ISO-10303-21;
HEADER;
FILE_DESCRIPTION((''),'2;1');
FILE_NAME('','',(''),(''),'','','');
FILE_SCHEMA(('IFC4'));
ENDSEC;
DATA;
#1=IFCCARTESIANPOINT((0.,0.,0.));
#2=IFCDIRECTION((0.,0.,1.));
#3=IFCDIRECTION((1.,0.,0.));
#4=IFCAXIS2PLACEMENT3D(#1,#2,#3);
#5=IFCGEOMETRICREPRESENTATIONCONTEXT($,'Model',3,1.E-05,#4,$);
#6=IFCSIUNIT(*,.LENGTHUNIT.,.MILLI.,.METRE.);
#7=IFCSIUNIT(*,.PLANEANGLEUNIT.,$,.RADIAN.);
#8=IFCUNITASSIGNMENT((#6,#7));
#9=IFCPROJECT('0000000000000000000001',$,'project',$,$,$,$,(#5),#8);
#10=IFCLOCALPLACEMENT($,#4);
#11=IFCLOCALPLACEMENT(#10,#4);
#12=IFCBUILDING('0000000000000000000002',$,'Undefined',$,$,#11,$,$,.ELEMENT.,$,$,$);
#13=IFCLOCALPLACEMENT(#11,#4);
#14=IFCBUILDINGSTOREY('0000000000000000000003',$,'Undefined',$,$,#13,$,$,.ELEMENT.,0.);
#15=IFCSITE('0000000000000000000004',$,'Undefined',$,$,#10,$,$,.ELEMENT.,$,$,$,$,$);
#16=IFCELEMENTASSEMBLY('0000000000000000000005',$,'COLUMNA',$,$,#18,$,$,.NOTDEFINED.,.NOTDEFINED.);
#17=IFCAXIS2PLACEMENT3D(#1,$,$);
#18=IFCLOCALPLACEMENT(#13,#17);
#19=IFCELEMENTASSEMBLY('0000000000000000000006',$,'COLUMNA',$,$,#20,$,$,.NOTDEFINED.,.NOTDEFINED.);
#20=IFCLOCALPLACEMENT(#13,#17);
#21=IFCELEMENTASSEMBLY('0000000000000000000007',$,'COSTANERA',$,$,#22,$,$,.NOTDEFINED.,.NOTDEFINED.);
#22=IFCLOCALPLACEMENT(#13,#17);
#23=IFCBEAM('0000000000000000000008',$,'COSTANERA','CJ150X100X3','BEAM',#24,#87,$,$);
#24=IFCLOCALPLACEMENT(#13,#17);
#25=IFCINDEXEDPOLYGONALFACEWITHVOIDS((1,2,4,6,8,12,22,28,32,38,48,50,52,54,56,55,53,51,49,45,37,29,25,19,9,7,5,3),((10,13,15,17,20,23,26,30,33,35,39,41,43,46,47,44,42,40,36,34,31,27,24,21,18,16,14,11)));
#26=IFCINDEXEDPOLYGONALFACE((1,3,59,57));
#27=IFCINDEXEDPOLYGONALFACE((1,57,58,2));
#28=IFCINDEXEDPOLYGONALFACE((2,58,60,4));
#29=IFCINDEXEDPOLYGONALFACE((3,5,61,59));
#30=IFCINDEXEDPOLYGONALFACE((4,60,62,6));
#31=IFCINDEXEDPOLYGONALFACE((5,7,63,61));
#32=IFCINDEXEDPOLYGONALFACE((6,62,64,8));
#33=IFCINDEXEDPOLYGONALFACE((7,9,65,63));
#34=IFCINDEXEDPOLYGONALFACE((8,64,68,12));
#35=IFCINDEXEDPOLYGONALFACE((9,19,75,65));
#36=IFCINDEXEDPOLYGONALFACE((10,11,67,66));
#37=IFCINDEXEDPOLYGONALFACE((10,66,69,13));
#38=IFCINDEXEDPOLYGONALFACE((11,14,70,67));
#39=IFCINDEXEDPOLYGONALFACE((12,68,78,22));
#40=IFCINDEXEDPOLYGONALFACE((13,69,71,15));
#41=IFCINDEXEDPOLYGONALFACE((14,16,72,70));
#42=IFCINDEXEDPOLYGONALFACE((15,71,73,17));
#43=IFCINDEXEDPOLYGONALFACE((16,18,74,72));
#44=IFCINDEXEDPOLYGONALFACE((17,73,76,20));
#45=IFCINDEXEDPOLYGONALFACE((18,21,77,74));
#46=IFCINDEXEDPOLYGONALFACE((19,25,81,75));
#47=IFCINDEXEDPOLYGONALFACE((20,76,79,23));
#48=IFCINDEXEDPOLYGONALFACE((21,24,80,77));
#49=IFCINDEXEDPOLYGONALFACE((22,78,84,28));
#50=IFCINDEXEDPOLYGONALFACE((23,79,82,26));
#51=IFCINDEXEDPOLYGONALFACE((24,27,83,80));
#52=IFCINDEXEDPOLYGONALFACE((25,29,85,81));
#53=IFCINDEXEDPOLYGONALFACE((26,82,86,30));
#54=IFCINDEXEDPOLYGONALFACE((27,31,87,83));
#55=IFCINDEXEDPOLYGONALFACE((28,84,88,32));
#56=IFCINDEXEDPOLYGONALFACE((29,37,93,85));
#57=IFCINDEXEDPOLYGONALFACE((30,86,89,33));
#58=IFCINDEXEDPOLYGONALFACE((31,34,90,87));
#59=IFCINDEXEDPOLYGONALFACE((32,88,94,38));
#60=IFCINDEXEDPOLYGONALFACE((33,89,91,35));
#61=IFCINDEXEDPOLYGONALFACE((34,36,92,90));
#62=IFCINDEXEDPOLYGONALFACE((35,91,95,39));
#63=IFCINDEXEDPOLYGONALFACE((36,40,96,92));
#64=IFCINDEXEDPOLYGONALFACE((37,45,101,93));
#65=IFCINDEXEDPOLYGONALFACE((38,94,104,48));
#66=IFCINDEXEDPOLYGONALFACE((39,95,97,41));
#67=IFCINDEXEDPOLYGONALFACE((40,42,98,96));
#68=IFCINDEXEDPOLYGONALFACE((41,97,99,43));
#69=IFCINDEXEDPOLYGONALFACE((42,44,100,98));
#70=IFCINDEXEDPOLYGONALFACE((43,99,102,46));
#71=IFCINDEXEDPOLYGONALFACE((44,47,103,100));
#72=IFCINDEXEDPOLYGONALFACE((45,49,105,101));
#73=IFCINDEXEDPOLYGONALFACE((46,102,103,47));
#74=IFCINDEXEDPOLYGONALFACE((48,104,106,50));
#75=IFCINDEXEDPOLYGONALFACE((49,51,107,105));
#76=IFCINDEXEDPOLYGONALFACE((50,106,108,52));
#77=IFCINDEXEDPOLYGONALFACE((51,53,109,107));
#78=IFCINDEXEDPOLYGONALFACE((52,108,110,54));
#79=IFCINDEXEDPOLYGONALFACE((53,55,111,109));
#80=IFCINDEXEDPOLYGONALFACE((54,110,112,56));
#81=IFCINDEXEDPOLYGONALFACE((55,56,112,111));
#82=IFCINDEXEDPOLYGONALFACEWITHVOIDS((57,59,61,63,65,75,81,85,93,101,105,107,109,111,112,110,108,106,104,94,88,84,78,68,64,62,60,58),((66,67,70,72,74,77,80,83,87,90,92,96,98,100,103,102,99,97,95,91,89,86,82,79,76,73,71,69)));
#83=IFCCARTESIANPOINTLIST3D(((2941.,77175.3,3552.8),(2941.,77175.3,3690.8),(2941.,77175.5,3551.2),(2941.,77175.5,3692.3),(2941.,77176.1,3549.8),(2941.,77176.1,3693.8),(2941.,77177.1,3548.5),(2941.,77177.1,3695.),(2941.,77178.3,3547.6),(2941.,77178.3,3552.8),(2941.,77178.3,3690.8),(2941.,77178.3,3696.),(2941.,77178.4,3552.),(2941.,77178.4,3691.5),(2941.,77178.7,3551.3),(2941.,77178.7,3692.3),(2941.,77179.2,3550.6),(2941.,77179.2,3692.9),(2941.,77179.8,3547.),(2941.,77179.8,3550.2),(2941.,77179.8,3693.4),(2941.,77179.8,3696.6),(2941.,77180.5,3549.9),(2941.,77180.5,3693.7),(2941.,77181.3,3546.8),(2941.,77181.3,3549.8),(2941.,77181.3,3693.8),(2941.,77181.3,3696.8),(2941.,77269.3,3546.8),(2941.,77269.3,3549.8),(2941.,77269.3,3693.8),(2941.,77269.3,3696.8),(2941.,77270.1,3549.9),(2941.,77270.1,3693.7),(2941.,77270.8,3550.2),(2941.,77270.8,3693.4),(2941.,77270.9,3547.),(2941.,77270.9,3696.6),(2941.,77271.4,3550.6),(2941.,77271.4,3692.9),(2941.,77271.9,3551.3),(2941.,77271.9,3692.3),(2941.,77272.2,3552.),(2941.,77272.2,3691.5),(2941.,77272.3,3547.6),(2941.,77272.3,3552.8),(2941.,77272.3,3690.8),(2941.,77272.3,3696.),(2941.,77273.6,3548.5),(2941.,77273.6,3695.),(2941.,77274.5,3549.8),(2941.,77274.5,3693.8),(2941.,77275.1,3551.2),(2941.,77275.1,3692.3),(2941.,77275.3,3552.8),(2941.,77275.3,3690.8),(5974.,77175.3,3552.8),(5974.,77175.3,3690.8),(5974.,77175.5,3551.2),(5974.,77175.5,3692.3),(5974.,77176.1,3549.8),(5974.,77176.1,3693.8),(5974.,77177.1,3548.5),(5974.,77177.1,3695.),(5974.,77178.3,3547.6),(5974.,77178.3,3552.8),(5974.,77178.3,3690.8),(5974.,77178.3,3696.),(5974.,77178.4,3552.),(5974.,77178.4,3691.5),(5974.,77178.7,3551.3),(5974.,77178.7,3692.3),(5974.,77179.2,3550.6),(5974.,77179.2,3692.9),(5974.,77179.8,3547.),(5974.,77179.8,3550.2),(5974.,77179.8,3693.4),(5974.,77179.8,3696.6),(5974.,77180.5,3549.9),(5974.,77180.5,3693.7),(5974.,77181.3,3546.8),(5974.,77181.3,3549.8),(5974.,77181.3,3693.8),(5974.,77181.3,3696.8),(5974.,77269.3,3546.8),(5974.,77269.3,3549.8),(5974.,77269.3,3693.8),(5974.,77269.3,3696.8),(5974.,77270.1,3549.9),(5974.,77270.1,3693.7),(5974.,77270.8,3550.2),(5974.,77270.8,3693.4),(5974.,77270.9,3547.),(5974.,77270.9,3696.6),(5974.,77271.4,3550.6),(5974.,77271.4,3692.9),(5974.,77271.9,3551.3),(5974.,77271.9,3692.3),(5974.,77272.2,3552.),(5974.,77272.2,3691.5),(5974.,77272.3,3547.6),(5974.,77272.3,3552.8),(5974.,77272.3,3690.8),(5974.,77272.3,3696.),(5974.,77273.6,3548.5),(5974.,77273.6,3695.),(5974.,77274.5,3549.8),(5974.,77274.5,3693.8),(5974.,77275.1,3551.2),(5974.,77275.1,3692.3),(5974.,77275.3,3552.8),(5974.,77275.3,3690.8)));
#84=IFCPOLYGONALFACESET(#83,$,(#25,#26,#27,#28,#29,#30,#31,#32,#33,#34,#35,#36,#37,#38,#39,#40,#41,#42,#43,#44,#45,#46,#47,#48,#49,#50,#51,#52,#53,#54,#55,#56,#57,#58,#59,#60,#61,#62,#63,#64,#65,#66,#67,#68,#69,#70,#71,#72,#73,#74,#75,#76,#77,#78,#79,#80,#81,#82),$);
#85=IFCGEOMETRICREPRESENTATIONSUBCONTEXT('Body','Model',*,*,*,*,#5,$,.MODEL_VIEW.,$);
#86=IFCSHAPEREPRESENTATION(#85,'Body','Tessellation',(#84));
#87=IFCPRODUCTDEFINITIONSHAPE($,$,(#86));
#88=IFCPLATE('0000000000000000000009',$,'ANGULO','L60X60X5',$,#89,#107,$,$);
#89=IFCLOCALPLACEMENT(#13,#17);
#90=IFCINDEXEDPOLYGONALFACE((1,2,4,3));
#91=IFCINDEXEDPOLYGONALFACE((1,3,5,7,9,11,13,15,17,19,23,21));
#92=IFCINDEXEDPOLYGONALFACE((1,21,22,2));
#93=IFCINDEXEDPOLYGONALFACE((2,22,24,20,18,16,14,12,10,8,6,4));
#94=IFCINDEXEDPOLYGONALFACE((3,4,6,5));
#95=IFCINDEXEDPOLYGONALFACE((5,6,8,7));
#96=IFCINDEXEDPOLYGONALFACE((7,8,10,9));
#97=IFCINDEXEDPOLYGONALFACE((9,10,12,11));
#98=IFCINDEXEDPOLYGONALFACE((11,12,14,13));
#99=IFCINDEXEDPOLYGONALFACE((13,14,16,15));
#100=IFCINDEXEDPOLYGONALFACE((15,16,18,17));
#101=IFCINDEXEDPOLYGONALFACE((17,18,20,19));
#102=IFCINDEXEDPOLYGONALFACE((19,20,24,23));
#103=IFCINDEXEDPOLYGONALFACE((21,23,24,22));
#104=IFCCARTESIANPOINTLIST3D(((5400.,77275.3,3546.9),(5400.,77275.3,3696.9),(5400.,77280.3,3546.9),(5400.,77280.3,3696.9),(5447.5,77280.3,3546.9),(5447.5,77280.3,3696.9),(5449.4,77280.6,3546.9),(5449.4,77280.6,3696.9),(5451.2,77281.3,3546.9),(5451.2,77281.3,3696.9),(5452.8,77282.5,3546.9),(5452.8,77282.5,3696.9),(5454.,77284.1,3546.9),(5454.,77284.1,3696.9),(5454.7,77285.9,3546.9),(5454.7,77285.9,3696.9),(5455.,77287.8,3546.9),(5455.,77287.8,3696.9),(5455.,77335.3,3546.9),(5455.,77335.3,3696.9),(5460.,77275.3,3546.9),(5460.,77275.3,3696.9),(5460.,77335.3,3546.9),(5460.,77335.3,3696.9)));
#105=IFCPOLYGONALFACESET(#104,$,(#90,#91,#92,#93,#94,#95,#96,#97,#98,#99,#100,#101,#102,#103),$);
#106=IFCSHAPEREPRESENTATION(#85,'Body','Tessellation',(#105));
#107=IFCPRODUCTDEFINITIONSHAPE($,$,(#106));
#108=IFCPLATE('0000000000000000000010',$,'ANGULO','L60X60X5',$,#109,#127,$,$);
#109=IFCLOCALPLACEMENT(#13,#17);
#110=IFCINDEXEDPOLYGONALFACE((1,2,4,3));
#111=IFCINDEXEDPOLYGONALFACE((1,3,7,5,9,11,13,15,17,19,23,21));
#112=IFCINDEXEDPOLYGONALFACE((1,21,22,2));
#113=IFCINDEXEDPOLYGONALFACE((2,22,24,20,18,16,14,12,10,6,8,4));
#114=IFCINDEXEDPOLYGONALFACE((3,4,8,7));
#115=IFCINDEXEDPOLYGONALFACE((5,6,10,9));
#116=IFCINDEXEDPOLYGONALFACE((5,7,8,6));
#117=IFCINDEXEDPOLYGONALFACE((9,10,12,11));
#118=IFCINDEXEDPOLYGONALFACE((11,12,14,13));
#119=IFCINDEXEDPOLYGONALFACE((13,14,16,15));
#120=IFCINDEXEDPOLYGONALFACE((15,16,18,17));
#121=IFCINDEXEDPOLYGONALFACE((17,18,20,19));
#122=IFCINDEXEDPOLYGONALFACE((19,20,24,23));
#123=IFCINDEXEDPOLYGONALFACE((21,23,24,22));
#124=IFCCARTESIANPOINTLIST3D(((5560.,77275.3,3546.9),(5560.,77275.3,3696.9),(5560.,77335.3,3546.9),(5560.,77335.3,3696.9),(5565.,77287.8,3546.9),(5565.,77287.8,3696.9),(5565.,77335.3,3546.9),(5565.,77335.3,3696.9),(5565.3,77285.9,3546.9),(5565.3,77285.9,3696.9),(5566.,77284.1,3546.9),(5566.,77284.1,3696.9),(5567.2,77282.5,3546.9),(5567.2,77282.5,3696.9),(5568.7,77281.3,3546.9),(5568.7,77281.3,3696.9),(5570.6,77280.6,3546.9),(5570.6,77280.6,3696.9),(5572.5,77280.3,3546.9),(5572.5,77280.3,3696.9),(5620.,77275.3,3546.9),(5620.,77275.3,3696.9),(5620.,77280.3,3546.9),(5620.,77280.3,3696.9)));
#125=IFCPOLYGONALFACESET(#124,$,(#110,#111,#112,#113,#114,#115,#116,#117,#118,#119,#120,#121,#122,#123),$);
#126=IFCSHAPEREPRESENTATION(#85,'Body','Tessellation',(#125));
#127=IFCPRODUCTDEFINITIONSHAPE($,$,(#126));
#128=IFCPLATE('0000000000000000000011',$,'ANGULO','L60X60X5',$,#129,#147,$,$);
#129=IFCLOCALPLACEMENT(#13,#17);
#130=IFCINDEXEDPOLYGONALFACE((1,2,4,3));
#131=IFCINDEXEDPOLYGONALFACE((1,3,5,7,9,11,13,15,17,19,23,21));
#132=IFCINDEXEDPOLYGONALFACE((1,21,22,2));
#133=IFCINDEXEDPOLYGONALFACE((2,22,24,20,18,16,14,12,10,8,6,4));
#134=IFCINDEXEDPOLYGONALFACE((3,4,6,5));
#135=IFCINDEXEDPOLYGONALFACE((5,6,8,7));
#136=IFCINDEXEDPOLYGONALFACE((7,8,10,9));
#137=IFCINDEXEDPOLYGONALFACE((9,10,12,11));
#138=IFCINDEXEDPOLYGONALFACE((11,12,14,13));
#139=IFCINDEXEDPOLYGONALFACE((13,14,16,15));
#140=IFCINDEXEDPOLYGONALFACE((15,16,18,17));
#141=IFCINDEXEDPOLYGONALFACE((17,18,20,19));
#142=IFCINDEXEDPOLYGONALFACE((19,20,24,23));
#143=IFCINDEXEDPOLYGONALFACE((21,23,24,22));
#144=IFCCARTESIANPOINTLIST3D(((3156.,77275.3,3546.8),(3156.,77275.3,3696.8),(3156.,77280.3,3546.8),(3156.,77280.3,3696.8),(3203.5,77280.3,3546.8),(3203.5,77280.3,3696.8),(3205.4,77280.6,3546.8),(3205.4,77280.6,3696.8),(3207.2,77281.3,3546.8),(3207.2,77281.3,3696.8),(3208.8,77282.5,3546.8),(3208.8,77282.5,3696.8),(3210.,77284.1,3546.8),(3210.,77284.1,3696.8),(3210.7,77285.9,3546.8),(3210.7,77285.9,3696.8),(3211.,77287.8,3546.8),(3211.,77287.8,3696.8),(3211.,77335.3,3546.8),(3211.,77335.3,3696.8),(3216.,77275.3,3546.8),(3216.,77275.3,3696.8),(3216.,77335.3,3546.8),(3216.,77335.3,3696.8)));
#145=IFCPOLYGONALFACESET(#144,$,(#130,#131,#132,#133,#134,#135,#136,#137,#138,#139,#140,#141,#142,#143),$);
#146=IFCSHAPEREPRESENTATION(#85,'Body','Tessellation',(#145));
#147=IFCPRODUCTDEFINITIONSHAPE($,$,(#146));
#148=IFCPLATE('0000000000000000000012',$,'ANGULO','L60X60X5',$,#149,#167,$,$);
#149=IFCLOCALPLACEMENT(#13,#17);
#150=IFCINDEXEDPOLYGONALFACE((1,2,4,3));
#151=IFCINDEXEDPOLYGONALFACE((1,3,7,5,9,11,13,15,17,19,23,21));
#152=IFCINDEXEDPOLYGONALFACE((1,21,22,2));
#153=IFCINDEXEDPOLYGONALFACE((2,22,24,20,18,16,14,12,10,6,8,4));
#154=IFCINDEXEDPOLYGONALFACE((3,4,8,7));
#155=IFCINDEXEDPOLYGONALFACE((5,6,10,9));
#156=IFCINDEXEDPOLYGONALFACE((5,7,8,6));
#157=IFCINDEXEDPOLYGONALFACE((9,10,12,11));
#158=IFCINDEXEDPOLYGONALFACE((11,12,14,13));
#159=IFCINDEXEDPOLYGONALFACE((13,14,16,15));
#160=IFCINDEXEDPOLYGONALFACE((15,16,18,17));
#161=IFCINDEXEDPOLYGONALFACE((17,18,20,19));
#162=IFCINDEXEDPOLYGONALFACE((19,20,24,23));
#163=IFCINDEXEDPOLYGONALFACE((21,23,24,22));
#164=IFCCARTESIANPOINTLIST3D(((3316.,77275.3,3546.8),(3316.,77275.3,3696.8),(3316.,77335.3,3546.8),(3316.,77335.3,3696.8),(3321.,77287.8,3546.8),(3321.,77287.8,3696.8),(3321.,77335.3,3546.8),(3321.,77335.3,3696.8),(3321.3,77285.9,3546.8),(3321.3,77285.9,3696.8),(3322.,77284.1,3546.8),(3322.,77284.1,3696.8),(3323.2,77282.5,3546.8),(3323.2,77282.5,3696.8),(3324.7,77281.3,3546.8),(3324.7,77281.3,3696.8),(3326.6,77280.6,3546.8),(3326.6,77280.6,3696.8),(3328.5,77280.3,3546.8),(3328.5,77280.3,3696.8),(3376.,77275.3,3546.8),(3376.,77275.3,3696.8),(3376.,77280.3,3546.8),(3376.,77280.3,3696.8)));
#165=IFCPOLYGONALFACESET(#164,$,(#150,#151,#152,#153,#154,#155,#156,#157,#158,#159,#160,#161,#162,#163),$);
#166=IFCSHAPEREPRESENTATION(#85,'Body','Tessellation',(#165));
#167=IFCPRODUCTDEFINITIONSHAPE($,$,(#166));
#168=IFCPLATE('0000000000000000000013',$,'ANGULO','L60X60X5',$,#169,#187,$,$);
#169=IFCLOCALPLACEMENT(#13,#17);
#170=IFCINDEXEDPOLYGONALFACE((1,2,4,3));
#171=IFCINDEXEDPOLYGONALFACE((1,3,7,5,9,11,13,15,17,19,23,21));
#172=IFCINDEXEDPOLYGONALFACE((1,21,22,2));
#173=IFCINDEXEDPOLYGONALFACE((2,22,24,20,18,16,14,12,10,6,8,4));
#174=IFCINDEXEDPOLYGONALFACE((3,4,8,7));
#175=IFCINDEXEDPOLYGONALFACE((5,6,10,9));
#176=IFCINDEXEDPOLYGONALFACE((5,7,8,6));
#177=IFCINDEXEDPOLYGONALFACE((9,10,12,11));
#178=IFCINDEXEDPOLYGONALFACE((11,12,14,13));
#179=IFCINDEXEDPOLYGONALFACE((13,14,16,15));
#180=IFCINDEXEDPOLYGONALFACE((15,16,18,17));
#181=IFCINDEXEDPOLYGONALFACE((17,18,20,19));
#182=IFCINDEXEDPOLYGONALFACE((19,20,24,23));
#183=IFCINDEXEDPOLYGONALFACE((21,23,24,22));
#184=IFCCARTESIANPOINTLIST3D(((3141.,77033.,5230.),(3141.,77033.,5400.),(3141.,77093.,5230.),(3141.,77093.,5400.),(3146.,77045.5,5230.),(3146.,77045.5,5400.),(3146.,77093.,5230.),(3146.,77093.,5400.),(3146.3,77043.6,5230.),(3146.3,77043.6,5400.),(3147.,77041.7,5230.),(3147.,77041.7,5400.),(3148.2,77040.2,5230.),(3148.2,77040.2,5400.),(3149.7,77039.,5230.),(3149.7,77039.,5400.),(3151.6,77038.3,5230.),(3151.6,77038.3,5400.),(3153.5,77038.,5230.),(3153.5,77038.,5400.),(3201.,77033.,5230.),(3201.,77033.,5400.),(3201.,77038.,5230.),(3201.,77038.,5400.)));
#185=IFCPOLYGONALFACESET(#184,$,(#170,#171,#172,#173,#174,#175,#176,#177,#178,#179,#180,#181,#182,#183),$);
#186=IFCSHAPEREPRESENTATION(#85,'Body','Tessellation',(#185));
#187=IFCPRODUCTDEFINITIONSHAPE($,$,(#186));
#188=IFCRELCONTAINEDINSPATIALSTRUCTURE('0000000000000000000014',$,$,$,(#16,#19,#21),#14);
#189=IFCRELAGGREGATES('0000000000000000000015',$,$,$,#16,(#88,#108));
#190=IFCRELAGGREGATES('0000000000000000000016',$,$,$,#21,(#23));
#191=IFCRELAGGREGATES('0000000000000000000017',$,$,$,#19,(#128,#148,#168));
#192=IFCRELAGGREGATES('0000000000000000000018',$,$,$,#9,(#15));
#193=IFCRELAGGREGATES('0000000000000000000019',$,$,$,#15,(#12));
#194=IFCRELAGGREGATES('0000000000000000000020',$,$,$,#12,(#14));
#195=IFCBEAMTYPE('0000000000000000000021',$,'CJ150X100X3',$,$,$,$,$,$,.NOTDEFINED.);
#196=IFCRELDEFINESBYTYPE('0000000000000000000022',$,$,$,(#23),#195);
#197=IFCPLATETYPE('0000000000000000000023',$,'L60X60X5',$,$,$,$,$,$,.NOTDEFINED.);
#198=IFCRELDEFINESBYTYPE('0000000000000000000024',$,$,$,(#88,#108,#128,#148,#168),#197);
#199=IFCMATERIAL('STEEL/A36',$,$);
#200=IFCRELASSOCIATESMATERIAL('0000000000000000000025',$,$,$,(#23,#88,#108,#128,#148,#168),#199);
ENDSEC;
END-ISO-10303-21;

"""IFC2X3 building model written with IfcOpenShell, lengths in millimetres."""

from ifc_helpers import new_model, si_unit, frame, origin_with_axes, origin_2d_with_axis, place, context, subcontext, project, spatial, hollow_rectangle, l_section, extrude, material, type_object, element, aggregate, save


model = new_model("IFC2X3")

# Units and contexts
model_context = context("Model", 3, precision=1e-05, world=origin_with_axes())
body_context = subcontext(model_context, "Body", "Model", "MODEL_VIEW")
ifc_project = project(units=[si_unit("LENGTHUNIT", "METRE", prefix="MILLI"), si_unit("PLANEANGLEUNIT", "RADIAN")], contexts=[model_context])

# Site, building, storey
site_placement = place(None, origin_with_axes())
site = spatial("IfcSite", under=ifc_project, at=site_placement, Name="Undefined", CompositionType="ELEMENT")
building_placement = place(site_placement, origin_with_axes())
building = spatial("IfcBuilding", under=site, at=building_placement, Name="Undefined", CompositionType="ELEMENT")
storey_placement = place(building_placement, origin_with_axes())
storey = spatial("IfcBuildingStorey", under=building, at=storey_placement, Name="Undefined", CompositionType="ELEMENT", Elevation=0.0)

# Element assemblies, beam
assembly_1_placement = place(storey_placement, origin_with_axes())
assembly_1 = element("IfcElementAssembly", 1, at=assembly_1_placement, inside=storey, Name="COLUMNA", AssemblyPlace="NOTDEFINED", PredefinedType="NOTDEFINED")
ifc_material_1 = material(Name="STEEL/A36")
assembly_2_placement = place(storey_placement, origin_with_axes())
assembly_2 = element("IfcElementAssembly", 2, at=assembly_2_placement, inside=storey, Name="COLUMNA", AssemblyPlace="NOTDEFINED", PredefinedType="NOTDEFINED")
assembly_3_placement = place(storey_placement, origin_with_axes())
assembly_3 = element("IfcElementAssembly", 3, at=assembly_3_placement, inside=storey, Name="COSTANERA", AssemblyPlace="NOTDEFINED", PredefinedType="NOTDEFINED")
beam_type_1 = type_object("IfcBeamType", Name="CJ150X100X3", PredefinedType="NOTDEFINED")
beam_1_placement = place(assembly_3_placement, frame((2941.0, 77225.3, 3621.8), z_axis=(0.0, 0.0, 1.0), x_axis=(1.0, 0.0, 0.0)))
beam_1 = element("IfcBeam", 4, at=beam_1_placement, type_object=beam_type_1, material=ifc_material_1, Name="COSTANERA", Description="CJ150X100X3", ObjectType="BEAM", context=body_context, shape_type="SweptSolid", body=[
    extrude(hollow_rectangle(XDim=100.0, YDim=150.0, WallThickness=3.0, InnerFilletRadius=3.0, OuterFilletRadius=6.0, at=origin_2d_with_axis()), frame((3033.0, 0.0, 0.0), z_axis=(-1.0, 0.0, 0.0), x_axis=(0.0, -1.0, 0.0)), (0.0, 0.0, 1.0), 3033.0),
])

# Plates
plate_type_1 = type_object("IfcPlateType", Name="L60X60X5", PredefinedType="NOTDEFINED")
plate_1_placement = place(assembly_1_placement, frame((5430.0, 77305.3, 3546.9), z_axis=(0.0, 1.0, 0.0), x_axis=(0.0, 0.0, 1.0)))
plate_1 = element("IfcPlate", 5, at=plate_1_placement, type_object=plate_type_1, material=ifc_material_1, Name="ANGULO", Description="L60X60X5", context=body_context, shape_type="SweptSolid", body=[
    extrude(l_section(Depth=60.0, Width=60.0, Thickness=5.0, FilletRadius=7.5, at=origin_2d_with_axis()), frame((150.0, 0.0, 0.0), z_axis=(-1.0, 0.0, 0.0), x_axis=(0.0, -1.0, 0.0)), (0.0, 0.0, 1.0), 150.0),
])
plate_2_placement = place(assembly_1_placement, frame((5590.0, 77305.3, 3696.9), z_axis=(0.0, 1.0, 0.0), x_axis=(0.0, 0.0, -1.0)))
plate_2 = element("IfcPlate", 6, at=plate_2_placement, type_object=plate_type_1, material=ifc_material_1, Name="ANGULO", Description="L60X60X5", context=body_context, shape_type="SweptSolid", body=[
    extrude(l_section(Depth=60.0, Width=60.0, Thickness=5.0, FilletRadius=7.5, at=origin_2d_with_axis()), frame((150.0, 0.0, 0.0), z_axis=(-1.0, 0.0, 0.0), x_axis=(0.0, -1.0, 0.0)), (0.0, 0.0, 1.0), 150.0),
])
plate_3_placement = place(assembly_2_placement, frame((3186.0, 77305.3, 3546.8), z_axis=(0.0, 1.0, 0.0), x_axis=(0.0, 0.0, 1.0)))
plate_3 = element("IfcPlate", 7, at=plate_3_placement, type_object=plate_type_1, material=ifc_material_1, Name="ANGULO", Description="L60X60X5", context=body_context, shape_type="SweptSolid", body=[
    extrude(l_section(Depth=60.0, Width=60.0, Thickness=5.0, FilletRadius=7.5, at=origin_2d_with_axis()), frame((150.0, 0.0, 0.0), z_axis=(-1.0, 0.0, 0.0), x_axis=(0.0, -1.0, 0.0)), (0.0, 0.0, 1.0), 150.0),
])
plate_4_placement = place(assembly_2_placement, frame((3346.0, 77305.3, 3696.8), z_axis=(0.0, 1.0, 0.0), x_axis=(0.0, 0.0, -1.0)))
plate_4 = element("IfcPlate", 8, at=plate_4_placement, type_object=plate_type_1, material=ifc_material_1, Name="ANGULO", Description="L60X60X5", context=body_context, shape_type="SweptSolid", body=[
    extrude(l_section(Depth=60.0, Width=60.0, Thickness=5.0, FilletRadius=7.5, at=origin_2d_with_axis()), frame((150.0, 0.0, 0.0), z_axis=(-1.0, 0.0, 0.0), x_axis=(0.0, -1.0, 0.0)), (0.0, 0.0, 1.0), 150.0),
])
plate_5_placement = place(assembly_2_placement, frame((3171.0, 77063.0, 5400.0), z_axis=(0.0, 1.0, 0.0), x_axis=(0.0, 0.0, -1.0)))
plate_5 = element("IfcPlate", 9, at=plate_5_placement, type_object=plate_type_1, material=ifc_material_1, Name="ANGULO", Description="L60X60X5", context=body_context, shape_type="SweptSolid", body=[
    extrude(l_section(Depth=60.0, Width=60.0, Thickness=5.0, FilletRadius=7.5, at=origin_2d_with_axis()), frame((170.0, 0.0, 0.0), z_axis=(-1.0, 0.0, 0.0), x_axis=(0.0, -1.0, 0.0)), (0.0, 0.0, 1.0), 170.0),
])
aggregate(assembly_1, [plate_1, plate_2])

aggregate(assembly_3, [beam_1])
aggregate(assembly_2, [plate_3, plate_4, plate_5])

save(model, "model.ifc")
